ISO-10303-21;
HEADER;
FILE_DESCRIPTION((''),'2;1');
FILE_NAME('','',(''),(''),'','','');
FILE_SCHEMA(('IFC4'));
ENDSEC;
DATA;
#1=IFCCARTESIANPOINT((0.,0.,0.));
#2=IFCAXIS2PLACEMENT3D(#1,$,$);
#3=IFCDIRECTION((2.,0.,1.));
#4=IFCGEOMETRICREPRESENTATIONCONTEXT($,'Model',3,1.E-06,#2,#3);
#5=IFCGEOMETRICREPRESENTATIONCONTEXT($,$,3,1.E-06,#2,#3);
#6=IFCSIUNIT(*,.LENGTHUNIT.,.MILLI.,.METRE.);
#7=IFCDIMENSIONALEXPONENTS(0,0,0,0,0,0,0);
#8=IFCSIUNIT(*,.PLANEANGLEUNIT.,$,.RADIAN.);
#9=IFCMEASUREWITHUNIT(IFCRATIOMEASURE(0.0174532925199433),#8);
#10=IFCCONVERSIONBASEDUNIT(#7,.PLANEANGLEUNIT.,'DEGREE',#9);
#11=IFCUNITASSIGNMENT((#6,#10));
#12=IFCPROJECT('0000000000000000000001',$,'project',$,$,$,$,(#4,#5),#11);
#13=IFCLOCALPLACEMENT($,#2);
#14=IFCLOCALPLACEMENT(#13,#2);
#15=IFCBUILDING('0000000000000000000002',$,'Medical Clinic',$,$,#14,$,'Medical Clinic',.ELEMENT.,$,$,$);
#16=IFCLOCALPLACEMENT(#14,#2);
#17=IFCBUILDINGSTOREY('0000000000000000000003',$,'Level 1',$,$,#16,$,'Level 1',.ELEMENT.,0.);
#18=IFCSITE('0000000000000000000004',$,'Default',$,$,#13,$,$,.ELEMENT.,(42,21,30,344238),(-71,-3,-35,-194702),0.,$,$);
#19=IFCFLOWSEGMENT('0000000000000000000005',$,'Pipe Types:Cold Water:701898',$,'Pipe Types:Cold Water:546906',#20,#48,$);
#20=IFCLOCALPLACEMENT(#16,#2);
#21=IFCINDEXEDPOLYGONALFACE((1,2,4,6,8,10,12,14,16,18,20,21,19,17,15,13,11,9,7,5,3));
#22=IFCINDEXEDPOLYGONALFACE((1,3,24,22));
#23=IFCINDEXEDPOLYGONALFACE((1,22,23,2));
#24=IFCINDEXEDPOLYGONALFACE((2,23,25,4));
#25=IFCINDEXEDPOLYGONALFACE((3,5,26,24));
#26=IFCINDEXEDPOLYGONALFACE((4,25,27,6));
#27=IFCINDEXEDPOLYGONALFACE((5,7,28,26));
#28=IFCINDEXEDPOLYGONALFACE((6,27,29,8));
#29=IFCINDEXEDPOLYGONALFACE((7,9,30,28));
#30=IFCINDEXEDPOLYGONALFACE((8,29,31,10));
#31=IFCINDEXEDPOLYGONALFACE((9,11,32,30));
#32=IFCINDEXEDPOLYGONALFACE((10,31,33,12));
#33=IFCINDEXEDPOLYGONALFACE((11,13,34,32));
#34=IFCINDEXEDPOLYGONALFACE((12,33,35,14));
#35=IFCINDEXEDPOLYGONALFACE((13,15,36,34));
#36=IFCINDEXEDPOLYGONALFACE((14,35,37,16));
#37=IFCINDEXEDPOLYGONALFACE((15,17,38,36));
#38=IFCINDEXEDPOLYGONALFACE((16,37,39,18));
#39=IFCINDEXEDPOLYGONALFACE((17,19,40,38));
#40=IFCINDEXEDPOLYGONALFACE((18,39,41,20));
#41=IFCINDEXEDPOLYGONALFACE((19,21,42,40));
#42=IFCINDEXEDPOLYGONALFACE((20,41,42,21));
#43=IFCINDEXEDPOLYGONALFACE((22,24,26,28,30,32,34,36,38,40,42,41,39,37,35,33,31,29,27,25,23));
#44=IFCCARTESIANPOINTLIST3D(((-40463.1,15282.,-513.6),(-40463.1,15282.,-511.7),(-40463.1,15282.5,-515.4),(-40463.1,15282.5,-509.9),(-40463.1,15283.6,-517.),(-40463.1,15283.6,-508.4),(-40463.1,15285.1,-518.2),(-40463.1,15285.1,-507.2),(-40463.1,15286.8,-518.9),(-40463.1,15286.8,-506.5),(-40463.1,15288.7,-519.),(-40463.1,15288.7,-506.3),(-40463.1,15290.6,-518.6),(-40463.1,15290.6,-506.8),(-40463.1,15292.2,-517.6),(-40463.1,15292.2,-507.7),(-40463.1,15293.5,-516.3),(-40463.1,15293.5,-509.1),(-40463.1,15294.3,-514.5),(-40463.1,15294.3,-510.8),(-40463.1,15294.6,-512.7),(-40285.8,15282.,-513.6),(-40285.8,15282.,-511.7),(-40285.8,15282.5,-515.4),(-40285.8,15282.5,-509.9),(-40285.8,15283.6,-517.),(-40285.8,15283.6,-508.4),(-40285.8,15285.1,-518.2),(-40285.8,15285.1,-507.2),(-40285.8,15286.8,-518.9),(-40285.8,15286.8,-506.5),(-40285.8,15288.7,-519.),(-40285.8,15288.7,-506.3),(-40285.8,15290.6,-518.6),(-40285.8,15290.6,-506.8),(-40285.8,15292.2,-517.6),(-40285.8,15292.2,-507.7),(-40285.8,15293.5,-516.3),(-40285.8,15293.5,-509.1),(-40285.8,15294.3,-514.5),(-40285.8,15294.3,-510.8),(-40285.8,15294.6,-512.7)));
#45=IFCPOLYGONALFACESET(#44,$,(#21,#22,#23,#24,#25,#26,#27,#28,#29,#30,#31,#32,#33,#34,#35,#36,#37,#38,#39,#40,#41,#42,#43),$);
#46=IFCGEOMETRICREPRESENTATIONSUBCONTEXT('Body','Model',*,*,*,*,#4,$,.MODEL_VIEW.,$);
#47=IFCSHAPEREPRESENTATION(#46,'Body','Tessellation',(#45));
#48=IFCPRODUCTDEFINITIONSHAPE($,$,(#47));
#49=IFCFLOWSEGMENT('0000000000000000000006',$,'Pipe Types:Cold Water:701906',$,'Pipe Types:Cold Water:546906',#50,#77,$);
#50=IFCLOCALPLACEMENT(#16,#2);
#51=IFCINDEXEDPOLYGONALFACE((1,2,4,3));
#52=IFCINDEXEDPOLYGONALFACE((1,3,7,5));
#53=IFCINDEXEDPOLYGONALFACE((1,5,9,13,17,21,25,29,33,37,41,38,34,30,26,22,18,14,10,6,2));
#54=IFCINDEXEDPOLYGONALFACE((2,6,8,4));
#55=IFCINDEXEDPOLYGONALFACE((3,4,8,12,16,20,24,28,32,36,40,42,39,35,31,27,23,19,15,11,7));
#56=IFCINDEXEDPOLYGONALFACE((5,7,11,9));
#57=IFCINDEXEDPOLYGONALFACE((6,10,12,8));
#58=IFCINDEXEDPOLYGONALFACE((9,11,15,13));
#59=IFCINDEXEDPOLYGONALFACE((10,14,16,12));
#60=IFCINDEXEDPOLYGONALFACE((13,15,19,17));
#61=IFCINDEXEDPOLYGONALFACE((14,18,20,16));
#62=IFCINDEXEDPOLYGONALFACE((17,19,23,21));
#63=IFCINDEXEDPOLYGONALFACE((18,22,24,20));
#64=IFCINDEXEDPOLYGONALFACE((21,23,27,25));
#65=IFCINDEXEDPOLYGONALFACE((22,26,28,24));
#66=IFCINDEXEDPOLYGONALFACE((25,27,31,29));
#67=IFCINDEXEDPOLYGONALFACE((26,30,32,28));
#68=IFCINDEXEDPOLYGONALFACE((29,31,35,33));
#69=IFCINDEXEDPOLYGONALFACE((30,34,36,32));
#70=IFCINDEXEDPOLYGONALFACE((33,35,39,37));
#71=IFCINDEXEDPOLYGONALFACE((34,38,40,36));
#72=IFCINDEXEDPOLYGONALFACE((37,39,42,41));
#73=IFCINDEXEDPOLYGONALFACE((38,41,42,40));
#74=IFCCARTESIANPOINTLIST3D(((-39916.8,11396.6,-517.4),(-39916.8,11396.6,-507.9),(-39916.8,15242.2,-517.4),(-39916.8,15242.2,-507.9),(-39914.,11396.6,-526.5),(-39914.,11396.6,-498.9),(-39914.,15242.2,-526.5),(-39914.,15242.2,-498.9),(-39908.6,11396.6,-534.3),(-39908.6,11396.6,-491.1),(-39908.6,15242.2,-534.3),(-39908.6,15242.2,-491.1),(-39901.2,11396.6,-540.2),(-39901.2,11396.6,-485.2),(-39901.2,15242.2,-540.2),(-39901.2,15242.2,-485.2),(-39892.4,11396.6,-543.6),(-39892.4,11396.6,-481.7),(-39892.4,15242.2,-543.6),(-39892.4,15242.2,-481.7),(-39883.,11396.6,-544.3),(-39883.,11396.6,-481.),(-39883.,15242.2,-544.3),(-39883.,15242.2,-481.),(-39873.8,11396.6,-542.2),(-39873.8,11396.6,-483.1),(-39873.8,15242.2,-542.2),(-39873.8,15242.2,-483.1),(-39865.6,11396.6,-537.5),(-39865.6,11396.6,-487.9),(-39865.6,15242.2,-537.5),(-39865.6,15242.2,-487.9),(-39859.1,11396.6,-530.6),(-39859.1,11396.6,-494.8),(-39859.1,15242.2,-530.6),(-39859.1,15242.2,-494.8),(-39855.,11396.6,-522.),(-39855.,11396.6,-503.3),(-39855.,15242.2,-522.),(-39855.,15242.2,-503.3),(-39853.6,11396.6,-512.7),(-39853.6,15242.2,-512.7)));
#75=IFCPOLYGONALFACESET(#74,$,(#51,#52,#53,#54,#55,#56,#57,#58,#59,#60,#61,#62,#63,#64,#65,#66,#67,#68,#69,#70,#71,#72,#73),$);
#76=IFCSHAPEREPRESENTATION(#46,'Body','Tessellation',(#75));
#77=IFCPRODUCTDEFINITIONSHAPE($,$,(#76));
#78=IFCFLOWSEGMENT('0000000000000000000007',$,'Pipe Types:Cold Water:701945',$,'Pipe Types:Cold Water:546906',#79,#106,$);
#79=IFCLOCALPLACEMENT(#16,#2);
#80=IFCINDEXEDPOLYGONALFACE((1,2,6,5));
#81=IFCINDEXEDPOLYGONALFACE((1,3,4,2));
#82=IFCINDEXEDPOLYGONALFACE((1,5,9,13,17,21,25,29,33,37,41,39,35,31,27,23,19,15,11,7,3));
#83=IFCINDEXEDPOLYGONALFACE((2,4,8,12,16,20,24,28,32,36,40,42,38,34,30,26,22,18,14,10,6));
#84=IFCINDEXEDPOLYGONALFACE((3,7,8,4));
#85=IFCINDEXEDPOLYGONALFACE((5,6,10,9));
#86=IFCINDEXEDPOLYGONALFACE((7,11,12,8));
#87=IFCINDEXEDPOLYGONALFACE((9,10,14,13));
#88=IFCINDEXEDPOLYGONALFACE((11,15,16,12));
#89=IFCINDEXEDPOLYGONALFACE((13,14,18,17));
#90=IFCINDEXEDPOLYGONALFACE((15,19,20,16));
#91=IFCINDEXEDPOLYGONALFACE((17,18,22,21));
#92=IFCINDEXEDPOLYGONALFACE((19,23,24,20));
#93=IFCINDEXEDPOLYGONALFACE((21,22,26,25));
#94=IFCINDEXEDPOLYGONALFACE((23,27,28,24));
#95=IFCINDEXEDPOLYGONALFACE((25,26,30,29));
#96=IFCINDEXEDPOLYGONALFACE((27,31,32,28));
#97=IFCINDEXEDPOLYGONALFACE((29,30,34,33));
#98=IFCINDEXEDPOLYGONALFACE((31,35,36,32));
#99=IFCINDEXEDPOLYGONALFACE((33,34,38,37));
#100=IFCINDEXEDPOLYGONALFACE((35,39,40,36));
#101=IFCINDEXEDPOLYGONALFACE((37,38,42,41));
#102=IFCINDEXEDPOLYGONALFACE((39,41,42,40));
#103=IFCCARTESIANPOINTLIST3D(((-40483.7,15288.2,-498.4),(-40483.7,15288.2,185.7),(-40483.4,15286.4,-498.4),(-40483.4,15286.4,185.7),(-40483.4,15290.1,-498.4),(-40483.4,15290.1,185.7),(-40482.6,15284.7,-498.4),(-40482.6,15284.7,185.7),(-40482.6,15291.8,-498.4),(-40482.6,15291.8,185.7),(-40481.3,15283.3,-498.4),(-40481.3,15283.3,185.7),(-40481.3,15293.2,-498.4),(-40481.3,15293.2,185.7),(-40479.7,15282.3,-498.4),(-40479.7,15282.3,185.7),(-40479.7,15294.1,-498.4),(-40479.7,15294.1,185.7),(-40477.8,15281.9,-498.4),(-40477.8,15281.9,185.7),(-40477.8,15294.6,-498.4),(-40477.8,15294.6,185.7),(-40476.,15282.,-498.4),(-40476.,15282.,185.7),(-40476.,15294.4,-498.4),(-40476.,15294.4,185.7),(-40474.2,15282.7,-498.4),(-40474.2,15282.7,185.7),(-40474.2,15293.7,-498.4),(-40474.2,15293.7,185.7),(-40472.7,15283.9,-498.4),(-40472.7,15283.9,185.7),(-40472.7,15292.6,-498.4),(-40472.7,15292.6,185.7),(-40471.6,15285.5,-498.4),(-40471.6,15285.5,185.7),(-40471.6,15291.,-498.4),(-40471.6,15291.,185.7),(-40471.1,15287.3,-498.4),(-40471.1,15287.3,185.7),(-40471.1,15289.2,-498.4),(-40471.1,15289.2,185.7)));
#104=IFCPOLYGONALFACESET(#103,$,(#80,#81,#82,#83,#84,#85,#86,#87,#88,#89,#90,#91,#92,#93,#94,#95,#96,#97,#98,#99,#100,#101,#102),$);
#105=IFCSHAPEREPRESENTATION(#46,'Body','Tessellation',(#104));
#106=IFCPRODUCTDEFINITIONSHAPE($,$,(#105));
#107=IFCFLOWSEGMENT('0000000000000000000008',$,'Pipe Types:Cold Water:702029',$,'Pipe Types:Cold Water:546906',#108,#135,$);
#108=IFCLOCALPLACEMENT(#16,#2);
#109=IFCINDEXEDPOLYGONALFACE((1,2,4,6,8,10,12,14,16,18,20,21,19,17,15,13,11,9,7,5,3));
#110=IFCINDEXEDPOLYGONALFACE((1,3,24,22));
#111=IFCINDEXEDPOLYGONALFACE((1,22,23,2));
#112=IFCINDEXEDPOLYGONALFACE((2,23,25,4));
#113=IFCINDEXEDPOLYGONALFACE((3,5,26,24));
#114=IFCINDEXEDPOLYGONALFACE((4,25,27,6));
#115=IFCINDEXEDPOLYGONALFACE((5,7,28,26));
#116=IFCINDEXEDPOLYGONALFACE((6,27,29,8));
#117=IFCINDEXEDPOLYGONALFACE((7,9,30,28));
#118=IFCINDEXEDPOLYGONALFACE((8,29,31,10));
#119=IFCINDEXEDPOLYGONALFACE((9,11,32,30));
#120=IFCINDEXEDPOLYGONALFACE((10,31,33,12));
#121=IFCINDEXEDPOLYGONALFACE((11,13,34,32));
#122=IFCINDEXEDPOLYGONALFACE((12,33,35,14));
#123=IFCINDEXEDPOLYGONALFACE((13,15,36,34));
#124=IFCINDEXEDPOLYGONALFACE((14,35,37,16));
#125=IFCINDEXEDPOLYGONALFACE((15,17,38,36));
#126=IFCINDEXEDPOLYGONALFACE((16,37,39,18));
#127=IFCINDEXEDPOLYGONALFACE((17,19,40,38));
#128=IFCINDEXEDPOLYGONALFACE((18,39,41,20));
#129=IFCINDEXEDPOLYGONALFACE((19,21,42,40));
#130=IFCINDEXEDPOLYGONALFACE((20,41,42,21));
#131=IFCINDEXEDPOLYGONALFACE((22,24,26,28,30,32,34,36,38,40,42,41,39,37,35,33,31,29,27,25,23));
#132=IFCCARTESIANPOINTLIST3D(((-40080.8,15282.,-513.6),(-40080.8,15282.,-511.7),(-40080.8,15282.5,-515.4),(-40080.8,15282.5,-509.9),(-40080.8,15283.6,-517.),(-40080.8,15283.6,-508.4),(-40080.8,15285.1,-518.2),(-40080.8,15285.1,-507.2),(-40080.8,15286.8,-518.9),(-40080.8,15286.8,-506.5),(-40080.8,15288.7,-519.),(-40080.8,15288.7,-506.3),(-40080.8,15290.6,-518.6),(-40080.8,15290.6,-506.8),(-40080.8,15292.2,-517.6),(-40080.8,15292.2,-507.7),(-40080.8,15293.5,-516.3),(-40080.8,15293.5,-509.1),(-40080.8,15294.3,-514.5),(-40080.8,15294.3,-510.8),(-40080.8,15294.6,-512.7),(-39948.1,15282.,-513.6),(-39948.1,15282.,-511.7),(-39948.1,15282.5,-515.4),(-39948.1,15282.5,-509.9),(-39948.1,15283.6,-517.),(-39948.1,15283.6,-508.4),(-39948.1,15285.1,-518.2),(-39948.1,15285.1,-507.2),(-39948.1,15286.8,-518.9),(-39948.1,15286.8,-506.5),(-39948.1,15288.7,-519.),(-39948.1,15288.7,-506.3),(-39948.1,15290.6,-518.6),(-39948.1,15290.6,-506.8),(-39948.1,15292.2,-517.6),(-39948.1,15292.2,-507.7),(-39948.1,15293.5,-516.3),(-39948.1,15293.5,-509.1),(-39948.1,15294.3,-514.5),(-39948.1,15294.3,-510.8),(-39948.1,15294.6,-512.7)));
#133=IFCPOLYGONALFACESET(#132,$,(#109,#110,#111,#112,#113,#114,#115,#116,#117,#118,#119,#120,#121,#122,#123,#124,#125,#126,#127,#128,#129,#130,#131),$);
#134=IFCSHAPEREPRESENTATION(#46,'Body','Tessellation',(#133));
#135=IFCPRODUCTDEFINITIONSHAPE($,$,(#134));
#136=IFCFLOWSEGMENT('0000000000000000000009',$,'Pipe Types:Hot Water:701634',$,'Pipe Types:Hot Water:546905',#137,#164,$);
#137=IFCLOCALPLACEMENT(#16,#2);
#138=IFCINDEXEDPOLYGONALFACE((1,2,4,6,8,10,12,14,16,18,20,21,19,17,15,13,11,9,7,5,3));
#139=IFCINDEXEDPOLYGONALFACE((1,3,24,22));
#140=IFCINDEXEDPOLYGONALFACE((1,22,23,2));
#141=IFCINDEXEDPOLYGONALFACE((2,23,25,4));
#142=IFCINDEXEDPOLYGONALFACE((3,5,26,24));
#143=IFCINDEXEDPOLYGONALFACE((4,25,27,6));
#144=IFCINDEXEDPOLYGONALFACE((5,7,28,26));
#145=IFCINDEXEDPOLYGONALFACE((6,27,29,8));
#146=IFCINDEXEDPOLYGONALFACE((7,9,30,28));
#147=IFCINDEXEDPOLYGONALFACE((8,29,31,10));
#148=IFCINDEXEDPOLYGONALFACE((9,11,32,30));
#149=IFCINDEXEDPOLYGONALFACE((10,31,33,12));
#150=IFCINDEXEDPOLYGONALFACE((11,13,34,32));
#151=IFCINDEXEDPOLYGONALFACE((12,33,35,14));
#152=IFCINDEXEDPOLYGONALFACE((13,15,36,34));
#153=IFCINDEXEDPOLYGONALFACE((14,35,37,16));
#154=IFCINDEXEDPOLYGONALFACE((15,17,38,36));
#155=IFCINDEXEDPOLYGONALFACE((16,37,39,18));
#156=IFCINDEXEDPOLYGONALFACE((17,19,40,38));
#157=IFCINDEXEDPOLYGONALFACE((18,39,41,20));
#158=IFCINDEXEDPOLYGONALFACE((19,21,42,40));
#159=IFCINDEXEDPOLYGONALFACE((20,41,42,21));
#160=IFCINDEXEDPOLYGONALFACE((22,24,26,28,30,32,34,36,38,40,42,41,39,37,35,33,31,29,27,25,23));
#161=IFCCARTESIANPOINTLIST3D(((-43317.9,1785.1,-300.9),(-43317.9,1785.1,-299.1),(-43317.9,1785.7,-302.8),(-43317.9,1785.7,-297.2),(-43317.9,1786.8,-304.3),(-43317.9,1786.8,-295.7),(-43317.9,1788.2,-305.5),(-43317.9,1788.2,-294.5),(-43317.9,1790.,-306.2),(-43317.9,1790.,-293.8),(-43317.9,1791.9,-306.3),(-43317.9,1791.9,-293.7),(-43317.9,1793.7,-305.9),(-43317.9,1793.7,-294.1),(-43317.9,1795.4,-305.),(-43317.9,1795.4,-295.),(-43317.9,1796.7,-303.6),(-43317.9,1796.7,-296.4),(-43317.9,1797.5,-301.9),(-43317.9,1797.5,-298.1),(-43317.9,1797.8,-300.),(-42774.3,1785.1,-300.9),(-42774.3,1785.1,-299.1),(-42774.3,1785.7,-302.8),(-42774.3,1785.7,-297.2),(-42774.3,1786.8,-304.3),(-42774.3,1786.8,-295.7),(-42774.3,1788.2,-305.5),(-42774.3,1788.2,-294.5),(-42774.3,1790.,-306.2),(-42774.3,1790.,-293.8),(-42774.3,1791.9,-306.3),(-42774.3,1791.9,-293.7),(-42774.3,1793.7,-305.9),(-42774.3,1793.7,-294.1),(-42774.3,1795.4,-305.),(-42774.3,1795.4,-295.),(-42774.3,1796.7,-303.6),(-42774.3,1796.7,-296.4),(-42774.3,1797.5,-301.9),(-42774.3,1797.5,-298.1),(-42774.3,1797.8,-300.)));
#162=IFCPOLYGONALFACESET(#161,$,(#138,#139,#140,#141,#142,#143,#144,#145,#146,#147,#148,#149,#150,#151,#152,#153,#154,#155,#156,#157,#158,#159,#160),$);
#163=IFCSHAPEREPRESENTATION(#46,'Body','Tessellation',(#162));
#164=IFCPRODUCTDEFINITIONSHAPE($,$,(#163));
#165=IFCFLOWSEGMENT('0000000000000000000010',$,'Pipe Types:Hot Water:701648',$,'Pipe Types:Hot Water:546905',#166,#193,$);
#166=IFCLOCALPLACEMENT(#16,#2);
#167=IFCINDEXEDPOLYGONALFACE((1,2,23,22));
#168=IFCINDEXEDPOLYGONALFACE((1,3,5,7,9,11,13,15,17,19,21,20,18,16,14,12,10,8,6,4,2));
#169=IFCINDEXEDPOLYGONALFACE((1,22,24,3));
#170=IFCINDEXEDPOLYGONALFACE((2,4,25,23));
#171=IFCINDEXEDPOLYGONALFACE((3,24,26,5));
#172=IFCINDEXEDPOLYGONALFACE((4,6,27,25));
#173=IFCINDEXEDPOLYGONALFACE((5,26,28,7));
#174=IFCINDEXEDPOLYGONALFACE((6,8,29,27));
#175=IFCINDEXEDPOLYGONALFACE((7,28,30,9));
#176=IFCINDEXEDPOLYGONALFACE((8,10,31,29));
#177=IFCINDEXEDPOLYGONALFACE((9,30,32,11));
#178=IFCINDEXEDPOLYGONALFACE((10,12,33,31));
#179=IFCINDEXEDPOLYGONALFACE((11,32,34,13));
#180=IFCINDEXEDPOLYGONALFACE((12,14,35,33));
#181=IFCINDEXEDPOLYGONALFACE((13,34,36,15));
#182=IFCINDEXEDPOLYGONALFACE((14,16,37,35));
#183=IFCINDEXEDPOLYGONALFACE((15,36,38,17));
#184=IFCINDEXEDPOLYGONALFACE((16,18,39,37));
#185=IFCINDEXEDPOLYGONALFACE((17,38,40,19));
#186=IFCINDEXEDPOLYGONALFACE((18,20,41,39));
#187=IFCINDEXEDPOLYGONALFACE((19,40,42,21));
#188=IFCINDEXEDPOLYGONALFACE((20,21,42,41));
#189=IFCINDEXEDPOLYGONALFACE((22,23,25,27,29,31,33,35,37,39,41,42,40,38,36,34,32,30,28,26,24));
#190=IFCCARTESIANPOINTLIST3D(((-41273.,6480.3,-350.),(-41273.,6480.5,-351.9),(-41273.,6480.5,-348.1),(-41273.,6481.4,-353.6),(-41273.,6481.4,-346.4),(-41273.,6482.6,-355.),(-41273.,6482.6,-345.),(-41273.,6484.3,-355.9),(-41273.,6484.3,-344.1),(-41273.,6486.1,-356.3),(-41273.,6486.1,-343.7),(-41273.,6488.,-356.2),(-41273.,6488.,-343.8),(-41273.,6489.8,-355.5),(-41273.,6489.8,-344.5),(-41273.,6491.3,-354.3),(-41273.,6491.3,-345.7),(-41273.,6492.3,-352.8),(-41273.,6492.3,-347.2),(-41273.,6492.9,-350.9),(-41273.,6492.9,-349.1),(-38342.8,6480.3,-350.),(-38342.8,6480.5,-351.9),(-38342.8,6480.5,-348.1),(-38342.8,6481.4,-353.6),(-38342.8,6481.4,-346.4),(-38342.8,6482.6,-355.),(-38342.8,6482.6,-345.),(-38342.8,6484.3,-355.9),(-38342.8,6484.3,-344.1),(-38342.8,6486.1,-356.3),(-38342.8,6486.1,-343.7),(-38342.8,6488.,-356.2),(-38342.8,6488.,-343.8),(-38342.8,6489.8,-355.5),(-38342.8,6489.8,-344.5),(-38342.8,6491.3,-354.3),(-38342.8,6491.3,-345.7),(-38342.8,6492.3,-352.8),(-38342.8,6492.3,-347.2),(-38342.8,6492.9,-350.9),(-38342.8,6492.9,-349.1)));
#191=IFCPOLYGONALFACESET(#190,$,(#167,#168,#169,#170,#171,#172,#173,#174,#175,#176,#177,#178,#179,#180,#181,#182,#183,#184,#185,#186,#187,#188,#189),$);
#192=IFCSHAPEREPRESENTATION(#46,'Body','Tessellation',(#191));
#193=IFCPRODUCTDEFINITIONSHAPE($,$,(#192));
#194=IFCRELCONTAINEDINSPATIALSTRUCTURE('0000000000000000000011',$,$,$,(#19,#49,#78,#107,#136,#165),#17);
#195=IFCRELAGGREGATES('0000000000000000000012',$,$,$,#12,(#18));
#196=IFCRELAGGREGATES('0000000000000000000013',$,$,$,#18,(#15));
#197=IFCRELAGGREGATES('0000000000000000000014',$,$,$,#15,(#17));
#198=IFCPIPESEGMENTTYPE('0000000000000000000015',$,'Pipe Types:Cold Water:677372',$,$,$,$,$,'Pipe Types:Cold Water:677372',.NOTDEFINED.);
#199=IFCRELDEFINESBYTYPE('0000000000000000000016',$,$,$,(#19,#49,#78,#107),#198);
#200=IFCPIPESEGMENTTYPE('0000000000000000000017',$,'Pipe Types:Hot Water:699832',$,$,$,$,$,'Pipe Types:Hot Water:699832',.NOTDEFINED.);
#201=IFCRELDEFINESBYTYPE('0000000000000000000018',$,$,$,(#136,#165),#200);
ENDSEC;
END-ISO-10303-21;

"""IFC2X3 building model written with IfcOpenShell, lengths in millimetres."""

from ifc_helpers import new_model, entity, si_unit, converted_unit, direction, frame, frame_2d, origin, origin_2d_with_axis, place, context, subcontext, project, spatial, circle, extrude, type_object, element, save


model = new_model("IFC2X3")

# Units and contexts
model_context = context("Model", 3, precision=1e-06, world=origin(), true_north=direction((2.0, 0.0, 1.0)))
context_of_model = context(None, 3, precision=1e-06, world=origin(), true_north=direction((2.0, 0.0, 1.0)))
body_context = subcontext(model_context, "Body", "Model", "MODEL_VIEW")
ifc_project = project(units=[si_unit("LENGTHUNIT", "METRE", prefix="MILLI"), converted_unit("PLANEANGLEUNIT", "DEGREE", entity("IfcRatioMeasure", 0.0174532925199433), si_unit("PLANEANGLEUNIT", "RADIAN"), dimensions=[0, 0, 0, 0, 0, 0, 0])], contexts=[model_context, context_of_model])

# Site, building, storey
site_placement = place(None, origin())
site = spatial("IfcSite", under=ifc_project, at=site_placement, Name="Default", CompositionType="ELEMENT", RefLatitude=(42, 21, 30, 344238), RefLongitude=(-71, -3, -35, -194702), RefElevation=0.0)
building_placement = place(site_placement, origin())
building = spatial("IfcBuilding", under=site, at=building_placement, Name="Medical Clinic", LongName="Medical Clinic", CompositionType="ELEMENT")
storey_placement = place(building_placement, origin())
storey = spatial("IfcBuildingStorey", under=building, at=storey_placement, Name="Level 1", LongName="Level 1", CompositionType="ELEMENT", Elevation=0.0)

# Flow segments
pipe_segment_type_1 = type_object("IfcPipeSegmentType", Name="Pipe Types:Cold Water:677372", ElementType="Pipe Types:Cold Water:677372", PredefinedType="NOTDEFINED")
flow_segment_1_placement = place(storey_placement, origin())
element("IfcFlowSegment", 1, at=flow_segment_1_placement, inside=storey, type_object=pipe_segment_type_1, Name="Pipe Types:Cold Water:701898", ObjectType="Pipe Types:Cold Water:546906", context=body_context, shape_type="SweptSolid", body=[
    extrude(circle(Radius=6.3, at=frame_2d((0.0, 0.0), x_axis=(1.0, 0.0))), frame((-40463.1, 15288.2, -512.7), z_axis=(1.0, 0.0, 0.0), x_axis=(0.0, 1.0, 0.0)), (0.0, 0.0, 1.0), 177.3),
])
flow_segment_2_placement = place(storey_placement, origin())
element("IfcFlowSegment", 2, at=flow_segment_2_placement, inside=storey, type_object=pipe_segment_type_1, Name="Pipe Types:Cold Water:701906", ObjectType="Pipe Types:Cold Water:546906", context=body_context, shape_type="SweptSolid", body=[
    extrude(circle(Radius=31.8, at=frame_2d((0.0, 0.0), x_axis=(1.0, 0.0))), frame((-39885.4, 11396.6, -512.7), z_axis=(0.0, 1.0, 0.0), x_axis=(1.0, 0.0, 0.0)), (0.0, 0.0, 1.0), 3845.6),
])
flow_segment_3_placement = place(storey_placement, origin())
element("IfcFlowSegment", 3, at=flow_segment_3_placement, inside=storey, type_object=pipe_segment_type_1, Name="Pipe Types:Cold Water:701945", ObjectType="Pipe Types:Cold Water:546906", context=body_context, shape_type="SweptSolid", body=[
    extrude(circle(Radius=6.3, at=origin_2d_with_axis()), frame((-40477.4, 15288.2, -498.4), z_axis=(0.0, 0.0, 1.0), x_axis=(-1.0, 0.0, 0.0)), (0.0, 0.0, 1.0), 684.1),
])
flow_segment_4_placement = place(storey_placement, origin())
element("IfcFlowSegment", 4, at=flow_segment_4_placement, inside=storey, type_object=pipe_segment_type_1, Name="Pipe Types:Cold Water:702029", ObjectType="Pipe Types:Cold Water:546906", context=body_context, shape_type="SweptSolid", body=[
    extrude(circle(Radius=6.3, at=frame_2d((0.0, 0.0), x_axis=(1.0, 0.0))), frame((-40080.8, 15288.2, -512.7), z_axis=(1.0, 0.0, 0.0), x_axis=(0.0, 1.0, 0.0)), (0.0, 0.0, 1.0), 132.8),
])
pipe_segment_type_2 = type_object("IfcPipeSegmentType", Name="Pipe Types:Hot Water:699832", ElementType="Pipe Types:Hot Water:699832", PredefinedType="NOTDEFINED")
flow_segment_5_placement = place(storey_placement, origin())
element("IfcFlowSegment", 5, at=flow_segment_5_placement, inside=storey, type_object=pipe_segment_type_2, Name="Pipe Types:Hot Water:701634", ObjectType="Pipe Types:Hot Water:546905", context=body_context, shape_type="SweptSolid", body=[
    extrude(circle(Radius=6.3, at=frame_2d((0.0, 0.0), x_axis=(1.0, 0.0))), frame((-43317.9, 1791.4, -300.0), z_axis=(1.0, 0.0, 0.0), x_axis=(0.0, 1.0, 0.0)), (0.0, 0.0, 1.0), 543.6),
])
flow_segment_6_placement = place(storey_placement, origin())
element("IfcFlowSegment", 6, at=flow_segment_6_placement, inside=storey, type_object=pipe_segment_type_2, Name="Pipe Types:Hot Water:701648", ObjectType="Pipe Types:Hot Water:546905", context=body_context, shape_type="SweptSolid", body=[
    extrude(circle(Radius=6.3, at=frame_2d((0.0, 0.0), x_axis=(1.0, 0.0))), frame((-41273.0, 6486.6, -350.0), z_axis=(1.0, 0.0, 0.0), x_axis=(0.0, -1.0, 0.0)), (0.0, 0.0, 1.0), 2930.3),
])

save(model, "model.ifc")
